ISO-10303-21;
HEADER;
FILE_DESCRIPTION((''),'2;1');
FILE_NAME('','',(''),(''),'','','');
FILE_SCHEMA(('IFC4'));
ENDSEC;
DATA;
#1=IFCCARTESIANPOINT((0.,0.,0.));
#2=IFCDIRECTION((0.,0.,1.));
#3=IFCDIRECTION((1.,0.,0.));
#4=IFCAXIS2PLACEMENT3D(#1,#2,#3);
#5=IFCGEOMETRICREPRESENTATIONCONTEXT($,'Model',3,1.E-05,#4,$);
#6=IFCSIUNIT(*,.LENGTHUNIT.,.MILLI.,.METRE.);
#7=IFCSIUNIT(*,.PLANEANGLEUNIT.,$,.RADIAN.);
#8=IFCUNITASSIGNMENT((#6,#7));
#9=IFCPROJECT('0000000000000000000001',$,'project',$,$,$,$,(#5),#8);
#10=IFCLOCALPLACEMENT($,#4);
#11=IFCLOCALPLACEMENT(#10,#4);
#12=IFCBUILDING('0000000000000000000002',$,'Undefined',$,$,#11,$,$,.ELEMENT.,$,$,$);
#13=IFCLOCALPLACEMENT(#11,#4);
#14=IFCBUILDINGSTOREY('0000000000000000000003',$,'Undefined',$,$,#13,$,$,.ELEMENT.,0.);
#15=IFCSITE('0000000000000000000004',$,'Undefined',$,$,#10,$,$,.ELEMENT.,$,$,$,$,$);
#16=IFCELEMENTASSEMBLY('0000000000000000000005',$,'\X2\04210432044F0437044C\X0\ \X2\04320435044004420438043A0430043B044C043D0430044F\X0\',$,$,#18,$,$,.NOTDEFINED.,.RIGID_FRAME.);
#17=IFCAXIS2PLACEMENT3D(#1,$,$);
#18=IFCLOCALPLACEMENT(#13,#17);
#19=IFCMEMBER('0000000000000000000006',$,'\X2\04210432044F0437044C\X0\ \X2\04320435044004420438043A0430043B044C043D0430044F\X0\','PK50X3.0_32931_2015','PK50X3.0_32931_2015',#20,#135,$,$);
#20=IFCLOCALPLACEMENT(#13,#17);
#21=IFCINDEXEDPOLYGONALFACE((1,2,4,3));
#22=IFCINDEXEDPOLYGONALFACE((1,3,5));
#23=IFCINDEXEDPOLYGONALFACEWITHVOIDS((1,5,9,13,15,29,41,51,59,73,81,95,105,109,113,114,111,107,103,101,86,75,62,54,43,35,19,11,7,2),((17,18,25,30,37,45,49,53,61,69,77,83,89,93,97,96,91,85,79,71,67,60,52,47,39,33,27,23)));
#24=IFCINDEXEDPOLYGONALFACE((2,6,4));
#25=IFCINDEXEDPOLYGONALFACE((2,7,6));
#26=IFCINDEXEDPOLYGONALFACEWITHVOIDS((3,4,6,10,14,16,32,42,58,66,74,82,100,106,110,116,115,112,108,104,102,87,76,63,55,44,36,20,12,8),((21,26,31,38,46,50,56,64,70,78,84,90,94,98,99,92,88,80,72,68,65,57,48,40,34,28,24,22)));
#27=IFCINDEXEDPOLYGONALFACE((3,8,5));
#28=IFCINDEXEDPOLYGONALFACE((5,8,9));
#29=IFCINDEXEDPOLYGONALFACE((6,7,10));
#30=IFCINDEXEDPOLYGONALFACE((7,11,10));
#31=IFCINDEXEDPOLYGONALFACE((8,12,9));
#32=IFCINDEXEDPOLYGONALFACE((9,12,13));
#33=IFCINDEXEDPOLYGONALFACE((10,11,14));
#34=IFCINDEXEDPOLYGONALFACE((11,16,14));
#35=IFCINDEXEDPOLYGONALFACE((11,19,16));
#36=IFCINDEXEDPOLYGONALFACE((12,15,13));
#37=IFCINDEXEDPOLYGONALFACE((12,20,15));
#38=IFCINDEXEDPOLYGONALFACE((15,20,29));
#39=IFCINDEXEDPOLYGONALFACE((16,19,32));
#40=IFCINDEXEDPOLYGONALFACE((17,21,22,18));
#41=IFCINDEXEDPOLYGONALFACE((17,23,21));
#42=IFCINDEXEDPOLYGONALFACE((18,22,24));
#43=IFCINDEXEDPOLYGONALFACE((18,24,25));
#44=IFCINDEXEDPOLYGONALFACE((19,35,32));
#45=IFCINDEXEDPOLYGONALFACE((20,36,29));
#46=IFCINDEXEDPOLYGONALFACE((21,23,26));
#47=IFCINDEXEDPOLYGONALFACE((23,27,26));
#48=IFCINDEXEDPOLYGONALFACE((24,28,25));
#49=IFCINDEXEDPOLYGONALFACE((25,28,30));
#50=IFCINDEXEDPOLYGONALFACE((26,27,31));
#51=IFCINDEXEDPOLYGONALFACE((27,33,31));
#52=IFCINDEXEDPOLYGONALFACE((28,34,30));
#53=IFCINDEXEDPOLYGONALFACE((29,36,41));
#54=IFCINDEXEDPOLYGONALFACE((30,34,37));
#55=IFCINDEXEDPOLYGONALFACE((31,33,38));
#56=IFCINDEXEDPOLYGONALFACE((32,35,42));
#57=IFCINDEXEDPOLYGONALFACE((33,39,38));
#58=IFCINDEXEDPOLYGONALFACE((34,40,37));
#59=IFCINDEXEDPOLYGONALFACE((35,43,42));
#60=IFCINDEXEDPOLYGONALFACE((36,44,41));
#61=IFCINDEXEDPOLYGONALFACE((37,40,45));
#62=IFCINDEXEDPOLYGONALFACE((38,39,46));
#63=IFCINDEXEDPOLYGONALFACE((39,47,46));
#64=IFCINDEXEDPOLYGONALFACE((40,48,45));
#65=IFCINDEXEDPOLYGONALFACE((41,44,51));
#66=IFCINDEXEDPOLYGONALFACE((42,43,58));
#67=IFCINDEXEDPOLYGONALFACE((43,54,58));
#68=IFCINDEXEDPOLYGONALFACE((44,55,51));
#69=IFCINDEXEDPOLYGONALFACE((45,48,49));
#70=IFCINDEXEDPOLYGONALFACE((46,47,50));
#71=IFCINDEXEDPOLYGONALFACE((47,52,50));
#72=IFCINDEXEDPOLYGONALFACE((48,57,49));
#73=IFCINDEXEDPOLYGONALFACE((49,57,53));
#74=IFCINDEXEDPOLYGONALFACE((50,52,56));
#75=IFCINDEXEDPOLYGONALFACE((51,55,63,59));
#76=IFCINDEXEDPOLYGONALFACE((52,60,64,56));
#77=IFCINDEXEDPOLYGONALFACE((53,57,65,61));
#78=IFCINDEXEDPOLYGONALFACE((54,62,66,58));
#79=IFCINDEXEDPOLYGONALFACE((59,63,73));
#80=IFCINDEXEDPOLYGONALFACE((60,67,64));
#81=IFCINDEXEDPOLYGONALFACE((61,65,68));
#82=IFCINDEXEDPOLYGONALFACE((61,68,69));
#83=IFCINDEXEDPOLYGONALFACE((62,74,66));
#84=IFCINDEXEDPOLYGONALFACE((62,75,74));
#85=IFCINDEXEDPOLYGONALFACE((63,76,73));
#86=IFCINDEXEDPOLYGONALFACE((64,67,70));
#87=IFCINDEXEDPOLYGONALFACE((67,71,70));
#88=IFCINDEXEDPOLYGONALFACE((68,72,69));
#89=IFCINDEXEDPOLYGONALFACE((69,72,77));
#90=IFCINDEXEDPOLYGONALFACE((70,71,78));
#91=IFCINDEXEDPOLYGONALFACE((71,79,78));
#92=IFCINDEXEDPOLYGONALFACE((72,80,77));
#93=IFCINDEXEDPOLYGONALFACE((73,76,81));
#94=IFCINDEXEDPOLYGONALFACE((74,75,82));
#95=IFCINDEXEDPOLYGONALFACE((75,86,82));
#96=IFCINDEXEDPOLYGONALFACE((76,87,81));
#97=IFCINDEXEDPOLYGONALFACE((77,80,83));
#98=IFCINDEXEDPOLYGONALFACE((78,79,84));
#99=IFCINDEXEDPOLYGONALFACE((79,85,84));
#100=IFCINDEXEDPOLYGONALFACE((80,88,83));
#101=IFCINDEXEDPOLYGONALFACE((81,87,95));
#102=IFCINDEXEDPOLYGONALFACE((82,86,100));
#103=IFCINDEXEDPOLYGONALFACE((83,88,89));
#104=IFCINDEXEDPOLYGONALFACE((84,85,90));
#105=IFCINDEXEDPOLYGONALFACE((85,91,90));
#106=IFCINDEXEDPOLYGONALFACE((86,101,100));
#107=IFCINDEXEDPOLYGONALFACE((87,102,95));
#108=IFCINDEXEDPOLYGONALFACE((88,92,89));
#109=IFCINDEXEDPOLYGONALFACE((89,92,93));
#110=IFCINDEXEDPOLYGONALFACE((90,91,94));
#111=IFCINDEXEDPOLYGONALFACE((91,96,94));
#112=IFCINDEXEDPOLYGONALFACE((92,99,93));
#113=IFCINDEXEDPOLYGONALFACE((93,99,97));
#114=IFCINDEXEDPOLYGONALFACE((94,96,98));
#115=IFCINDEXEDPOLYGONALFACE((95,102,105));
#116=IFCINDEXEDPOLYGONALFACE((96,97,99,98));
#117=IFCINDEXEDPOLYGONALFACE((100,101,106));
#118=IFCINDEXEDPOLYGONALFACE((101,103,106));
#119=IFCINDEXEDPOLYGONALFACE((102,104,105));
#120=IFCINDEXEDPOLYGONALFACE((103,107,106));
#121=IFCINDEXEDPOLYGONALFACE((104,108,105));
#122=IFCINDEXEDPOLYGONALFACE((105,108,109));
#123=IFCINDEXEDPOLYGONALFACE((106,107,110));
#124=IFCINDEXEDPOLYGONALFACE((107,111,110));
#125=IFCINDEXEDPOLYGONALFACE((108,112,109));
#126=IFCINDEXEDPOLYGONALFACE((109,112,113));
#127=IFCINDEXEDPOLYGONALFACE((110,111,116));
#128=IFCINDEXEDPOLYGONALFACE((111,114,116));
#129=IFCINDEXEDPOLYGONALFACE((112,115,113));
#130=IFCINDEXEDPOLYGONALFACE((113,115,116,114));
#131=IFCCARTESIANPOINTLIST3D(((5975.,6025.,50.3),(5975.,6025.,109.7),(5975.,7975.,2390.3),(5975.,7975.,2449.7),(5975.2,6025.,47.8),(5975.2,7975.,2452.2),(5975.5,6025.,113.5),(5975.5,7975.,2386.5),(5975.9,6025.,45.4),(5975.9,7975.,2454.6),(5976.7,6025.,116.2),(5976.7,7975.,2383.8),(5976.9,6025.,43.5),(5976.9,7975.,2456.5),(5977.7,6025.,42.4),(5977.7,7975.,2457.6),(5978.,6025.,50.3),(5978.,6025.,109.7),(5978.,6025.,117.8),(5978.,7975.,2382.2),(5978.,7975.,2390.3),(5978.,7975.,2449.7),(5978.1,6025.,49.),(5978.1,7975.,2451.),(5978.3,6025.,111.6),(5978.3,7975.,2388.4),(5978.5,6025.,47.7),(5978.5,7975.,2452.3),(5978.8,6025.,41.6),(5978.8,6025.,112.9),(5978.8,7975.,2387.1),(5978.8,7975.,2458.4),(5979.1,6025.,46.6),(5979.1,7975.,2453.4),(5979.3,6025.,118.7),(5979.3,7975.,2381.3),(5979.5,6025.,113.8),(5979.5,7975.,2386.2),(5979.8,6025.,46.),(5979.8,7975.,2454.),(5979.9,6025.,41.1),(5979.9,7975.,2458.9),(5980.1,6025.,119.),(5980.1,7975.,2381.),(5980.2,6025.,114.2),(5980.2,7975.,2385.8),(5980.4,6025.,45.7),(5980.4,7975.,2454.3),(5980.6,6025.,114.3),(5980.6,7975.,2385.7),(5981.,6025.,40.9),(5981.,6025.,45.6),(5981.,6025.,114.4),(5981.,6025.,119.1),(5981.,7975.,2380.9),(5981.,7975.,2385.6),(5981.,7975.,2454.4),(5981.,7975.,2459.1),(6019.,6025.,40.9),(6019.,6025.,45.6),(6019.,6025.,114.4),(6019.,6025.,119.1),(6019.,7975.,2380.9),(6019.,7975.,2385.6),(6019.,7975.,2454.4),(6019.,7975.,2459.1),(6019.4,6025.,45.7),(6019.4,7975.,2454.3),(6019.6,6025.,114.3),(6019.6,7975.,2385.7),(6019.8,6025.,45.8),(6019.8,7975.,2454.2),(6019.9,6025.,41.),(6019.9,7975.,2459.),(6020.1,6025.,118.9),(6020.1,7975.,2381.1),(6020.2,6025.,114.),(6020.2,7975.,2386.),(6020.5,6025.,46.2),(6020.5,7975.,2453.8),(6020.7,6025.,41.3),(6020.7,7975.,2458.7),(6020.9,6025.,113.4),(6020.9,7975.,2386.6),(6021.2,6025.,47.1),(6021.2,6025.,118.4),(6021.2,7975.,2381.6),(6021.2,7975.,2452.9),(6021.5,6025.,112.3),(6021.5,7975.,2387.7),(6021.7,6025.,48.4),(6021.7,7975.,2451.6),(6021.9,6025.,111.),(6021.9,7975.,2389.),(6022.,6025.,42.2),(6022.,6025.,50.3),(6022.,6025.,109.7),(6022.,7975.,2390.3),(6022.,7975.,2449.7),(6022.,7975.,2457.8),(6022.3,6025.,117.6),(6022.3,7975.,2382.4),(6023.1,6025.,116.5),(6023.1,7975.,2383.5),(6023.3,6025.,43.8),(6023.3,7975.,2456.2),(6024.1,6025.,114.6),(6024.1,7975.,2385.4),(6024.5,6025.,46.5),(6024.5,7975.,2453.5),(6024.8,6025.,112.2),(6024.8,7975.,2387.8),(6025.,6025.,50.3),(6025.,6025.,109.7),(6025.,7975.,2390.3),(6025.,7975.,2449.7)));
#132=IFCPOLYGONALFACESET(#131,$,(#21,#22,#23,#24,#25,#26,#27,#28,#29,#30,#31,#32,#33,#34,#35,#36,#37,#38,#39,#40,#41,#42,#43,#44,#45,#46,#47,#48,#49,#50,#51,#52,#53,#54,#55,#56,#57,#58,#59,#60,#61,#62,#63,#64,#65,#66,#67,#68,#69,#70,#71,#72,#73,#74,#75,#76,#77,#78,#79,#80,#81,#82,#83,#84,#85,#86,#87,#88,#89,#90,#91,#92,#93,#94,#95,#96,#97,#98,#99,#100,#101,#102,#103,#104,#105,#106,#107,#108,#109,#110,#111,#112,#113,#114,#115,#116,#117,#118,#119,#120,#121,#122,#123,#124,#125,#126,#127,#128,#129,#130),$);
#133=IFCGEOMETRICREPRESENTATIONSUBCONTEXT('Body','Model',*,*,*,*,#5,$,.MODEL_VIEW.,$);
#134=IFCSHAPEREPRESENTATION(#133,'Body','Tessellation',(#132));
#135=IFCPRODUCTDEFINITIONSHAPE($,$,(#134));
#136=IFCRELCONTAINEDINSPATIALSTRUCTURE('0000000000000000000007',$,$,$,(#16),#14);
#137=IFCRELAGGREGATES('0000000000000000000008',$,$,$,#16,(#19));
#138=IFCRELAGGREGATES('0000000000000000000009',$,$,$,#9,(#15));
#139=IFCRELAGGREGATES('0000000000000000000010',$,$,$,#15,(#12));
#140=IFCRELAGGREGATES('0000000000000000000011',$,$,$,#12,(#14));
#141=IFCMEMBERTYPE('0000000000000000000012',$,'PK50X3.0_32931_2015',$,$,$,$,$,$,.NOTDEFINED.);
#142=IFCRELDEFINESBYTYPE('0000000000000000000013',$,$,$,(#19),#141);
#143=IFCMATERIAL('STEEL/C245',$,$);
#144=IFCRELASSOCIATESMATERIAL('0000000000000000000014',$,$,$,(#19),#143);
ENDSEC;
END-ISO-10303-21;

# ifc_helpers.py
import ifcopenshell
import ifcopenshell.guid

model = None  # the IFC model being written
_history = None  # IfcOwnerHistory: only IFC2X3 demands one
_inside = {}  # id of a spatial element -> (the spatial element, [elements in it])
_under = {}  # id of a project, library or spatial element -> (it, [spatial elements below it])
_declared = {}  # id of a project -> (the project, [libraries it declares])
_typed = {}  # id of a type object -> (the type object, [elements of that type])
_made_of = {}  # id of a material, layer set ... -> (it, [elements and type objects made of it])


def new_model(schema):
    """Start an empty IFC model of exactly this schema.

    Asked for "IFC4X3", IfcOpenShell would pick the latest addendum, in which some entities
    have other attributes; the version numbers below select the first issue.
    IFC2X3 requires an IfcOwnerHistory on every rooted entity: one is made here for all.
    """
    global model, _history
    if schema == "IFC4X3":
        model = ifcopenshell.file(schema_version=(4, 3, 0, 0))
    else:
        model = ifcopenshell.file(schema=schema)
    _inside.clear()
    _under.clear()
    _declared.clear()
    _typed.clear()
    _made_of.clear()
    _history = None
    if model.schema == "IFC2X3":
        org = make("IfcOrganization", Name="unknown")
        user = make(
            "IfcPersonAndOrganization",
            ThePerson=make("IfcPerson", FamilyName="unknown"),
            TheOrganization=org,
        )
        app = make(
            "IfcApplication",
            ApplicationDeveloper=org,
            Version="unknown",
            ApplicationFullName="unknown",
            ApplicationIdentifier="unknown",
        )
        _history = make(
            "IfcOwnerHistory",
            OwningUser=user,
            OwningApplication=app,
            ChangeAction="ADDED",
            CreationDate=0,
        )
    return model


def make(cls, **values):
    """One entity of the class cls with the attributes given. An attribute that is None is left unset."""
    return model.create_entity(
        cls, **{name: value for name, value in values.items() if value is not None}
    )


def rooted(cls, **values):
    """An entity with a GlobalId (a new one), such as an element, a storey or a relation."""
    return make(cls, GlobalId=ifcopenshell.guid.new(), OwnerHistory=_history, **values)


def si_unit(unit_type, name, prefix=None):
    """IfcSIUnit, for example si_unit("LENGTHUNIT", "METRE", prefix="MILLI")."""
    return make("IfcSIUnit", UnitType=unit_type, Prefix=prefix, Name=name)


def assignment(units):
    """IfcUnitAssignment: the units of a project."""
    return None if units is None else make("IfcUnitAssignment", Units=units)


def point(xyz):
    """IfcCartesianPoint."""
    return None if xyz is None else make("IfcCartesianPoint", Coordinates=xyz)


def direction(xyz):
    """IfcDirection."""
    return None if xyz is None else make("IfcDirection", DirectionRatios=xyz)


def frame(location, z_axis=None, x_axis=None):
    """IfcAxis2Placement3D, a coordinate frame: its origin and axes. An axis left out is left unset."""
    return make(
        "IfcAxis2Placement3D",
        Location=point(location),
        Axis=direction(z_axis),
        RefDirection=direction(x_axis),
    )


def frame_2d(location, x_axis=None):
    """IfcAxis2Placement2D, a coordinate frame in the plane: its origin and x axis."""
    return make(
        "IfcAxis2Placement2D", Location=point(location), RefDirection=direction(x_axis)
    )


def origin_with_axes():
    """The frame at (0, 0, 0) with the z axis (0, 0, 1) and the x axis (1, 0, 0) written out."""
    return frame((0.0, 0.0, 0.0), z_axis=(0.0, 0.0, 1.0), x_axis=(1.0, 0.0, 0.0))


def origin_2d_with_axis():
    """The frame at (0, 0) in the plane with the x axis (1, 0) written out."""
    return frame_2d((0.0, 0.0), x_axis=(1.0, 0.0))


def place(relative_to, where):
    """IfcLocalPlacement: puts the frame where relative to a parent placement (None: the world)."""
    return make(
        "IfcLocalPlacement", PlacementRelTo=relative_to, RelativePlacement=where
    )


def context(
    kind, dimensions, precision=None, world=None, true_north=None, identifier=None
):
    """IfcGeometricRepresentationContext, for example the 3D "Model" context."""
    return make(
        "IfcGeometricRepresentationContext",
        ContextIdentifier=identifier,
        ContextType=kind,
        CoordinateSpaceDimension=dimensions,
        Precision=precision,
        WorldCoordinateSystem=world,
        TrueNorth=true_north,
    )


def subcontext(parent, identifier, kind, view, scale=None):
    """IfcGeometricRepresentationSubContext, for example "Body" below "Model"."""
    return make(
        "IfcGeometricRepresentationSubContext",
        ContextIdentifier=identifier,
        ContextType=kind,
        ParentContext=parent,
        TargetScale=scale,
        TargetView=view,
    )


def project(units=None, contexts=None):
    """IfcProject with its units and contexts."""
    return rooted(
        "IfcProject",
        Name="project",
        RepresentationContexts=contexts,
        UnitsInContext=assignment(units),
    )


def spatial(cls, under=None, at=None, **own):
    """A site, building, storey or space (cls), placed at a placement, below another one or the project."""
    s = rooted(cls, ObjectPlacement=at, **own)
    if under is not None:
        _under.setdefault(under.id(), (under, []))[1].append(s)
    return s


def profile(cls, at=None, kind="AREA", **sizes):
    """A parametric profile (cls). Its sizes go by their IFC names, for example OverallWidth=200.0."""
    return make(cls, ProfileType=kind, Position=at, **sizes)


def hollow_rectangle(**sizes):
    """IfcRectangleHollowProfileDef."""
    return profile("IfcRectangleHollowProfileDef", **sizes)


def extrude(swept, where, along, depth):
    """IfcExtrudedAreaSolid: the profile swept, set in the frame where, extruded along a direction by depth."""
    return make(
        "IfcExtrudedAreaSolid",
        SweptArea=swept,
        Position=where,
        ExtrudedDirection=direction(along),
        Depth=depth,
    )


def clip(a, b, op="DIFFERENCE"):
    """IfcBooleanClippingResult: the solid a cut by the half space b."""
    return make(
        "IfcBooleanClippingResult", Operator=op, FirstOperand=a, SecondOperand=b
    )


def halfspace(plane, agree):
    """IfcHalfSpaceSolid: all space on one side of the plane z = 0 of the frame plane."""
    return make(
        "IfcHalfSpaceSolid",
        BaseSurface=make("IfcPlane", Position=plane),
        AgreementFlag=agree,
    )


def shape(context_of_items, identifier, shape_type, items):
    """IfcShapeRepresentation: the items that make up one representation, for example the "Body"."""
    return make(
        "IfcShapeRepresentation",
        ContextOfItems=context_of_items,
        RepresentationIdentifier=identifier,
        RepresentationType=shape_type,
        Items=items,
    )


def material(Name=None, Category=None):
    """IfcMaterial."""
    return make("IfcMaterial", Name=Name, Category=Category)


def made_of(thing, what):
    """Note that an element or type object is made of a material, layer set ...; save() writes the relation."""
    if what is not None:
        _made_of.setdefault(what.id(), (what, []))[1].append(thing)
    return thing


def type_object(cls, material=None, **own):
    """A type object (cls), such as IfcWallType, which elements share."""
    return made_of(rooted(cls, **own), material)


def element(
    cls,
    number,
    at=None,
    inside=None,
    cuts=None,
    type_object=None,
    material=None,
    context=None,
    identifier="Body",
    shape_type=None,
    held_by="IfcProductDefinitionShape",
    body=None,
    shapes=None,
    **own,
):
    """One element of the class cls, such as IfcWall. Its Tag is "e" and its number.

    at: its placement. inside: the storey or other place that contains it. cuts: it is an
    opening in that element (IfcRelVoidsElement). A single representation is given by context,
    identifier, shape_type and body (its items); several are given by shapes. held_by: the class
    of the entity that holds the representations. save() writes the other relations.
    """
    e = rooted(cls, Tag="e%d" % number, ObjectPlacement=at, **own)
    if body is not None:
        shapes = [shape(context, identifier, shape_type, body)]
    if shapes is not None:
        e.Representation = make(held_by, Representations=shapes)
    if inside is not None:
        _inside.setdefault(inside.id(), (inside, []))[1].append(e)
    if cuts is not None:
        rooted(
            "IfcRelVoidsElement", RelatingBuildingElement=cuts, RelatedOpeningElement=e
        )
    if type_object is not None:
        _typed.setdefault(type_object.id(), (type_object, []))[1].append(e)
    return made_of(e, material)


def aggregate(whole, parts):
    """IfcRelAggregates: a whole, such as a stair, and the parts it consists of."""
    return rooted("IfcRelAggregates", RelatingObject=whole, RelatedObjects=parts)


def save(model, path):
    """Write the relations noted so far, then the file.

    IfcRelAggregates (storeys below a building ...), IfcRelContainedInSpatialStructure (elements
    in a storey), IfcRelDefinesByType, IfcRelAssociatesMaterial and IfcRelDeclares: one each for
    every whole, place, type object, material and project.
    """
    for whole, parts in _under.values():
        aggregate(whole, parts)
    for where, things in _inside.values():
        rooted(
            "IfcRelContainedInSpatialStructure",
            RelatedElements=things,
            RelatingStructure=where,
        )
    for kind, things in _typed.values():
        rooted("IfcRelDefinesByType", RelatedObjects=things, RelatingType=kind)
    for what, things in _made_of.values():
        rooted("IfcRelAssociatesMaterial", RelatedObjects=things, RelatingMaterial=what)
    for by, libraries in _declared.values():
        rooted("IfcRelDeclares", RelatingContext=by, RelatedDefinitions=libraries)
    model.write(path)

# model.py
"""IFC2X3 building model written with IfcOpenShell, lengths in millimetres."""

from ifc_helpers import new_model, si_unit, frame, origin_with_axes, origin_2d_with_axis, place, context, subcontext, project, spatial, hollow_rectangle, extrude, clip, halfspace, material, type_object, element, aggregate, save


model = new_model("IFC2X3")

# Units and contexts
model_context = context("Model", 3, precision=1e-05, world=origin_with_axes())
body_context = subcontext(model_context, "Body", "Model", "MODEL_VIEW")
ifc_project = project(units=[si_unit("LENGTHUNIT", "METRE", prefix="MILLI"), si_unit("PLANEANGLEUNIT", "RADIAN")], contexts=[model_context])

# Site, building, storey
site_placement = place(None, origin_with_axes())
site = spatial("IfcSite", under=ifc_project, at=site_placement, Name="Undefined", CompositionType="ELEMENT")
building_placement = place(site_placement, origin_with_axes())
building = spatial("IfcBuilding", under=site, at=building_placement, Name="Undefined", CompositionType="ELEMENT")
storey_placement = place(building_placement, origin_with_axes())
storey = spatial("IfcBuildingStorey", under=building, at=storey_placement, Name="Undefined", CompositionType="ELEMENT", Elevation=0.0)

# Shared definitions
ifc_material_1 = material(Name="STEEL/C245")

# Element assembly, member
member_type_1 = type_object("IfcMemberType", Name="PK50X3.0_32931_2015", PredefinedType="NOTDEFINED")
assembly_1_placement = place(storey_placement, origin_with_axes())
assembly_1 = element("IfcElementAssembly", 1, at=assembly_1_placement, inside=storey, Name="Связь вертикальная", AssemblyPlace="NOTDEFINED", PredefinedType="RIGID_FRAME")
member_1_placement = place(assembly_1_placement, frame((6000.0, 6000.0, 50.0), z_axis=(0.0, -0.768221, 0.640184), x_axis=(0.0, 0.640184, 0.768221)))
member_1 = element("IfcMember", 2, at=member_1_placement, type_object=member_type_1, material=ifc_material_1, Name="Связь вертикальная", Description="PK50X3.0_32931_2015", ObjectType="PK50X3.0_32931_2015", context=body_context, shape_type="Clipping", body=[
    clip(clip(extrude(hollow_rectangle(XDim=50.0, YDim=50.0, WallThickness=3.0, InnerFilletRadius=3.0, OuterFilletRadius=6.0, at=origin_2d_with_axis()), frame((3145.6, 0.0, 0.0), z_axis=(-1.0, 0.0, 0.0), x_axis=(0.0, -1.0, 0.0)), (0.0, 0.0, 1.0), 3167.2), halfspace(frame((2980.1, 0.0, -87.5), z_axis=(-0.640184, 0.0, 0.768221), x_axis=(0.0, -1.0, 0.0)), True)), halfspace(frame((8.9, 0.0, -25.1), z_axis=(0.640184, 0.0, -0.768221), x_axis=(0.0, -1.0, 0.0)), True)),
])
aggregate(assembly_1, [member_1])

save(model, "model.ifc")
